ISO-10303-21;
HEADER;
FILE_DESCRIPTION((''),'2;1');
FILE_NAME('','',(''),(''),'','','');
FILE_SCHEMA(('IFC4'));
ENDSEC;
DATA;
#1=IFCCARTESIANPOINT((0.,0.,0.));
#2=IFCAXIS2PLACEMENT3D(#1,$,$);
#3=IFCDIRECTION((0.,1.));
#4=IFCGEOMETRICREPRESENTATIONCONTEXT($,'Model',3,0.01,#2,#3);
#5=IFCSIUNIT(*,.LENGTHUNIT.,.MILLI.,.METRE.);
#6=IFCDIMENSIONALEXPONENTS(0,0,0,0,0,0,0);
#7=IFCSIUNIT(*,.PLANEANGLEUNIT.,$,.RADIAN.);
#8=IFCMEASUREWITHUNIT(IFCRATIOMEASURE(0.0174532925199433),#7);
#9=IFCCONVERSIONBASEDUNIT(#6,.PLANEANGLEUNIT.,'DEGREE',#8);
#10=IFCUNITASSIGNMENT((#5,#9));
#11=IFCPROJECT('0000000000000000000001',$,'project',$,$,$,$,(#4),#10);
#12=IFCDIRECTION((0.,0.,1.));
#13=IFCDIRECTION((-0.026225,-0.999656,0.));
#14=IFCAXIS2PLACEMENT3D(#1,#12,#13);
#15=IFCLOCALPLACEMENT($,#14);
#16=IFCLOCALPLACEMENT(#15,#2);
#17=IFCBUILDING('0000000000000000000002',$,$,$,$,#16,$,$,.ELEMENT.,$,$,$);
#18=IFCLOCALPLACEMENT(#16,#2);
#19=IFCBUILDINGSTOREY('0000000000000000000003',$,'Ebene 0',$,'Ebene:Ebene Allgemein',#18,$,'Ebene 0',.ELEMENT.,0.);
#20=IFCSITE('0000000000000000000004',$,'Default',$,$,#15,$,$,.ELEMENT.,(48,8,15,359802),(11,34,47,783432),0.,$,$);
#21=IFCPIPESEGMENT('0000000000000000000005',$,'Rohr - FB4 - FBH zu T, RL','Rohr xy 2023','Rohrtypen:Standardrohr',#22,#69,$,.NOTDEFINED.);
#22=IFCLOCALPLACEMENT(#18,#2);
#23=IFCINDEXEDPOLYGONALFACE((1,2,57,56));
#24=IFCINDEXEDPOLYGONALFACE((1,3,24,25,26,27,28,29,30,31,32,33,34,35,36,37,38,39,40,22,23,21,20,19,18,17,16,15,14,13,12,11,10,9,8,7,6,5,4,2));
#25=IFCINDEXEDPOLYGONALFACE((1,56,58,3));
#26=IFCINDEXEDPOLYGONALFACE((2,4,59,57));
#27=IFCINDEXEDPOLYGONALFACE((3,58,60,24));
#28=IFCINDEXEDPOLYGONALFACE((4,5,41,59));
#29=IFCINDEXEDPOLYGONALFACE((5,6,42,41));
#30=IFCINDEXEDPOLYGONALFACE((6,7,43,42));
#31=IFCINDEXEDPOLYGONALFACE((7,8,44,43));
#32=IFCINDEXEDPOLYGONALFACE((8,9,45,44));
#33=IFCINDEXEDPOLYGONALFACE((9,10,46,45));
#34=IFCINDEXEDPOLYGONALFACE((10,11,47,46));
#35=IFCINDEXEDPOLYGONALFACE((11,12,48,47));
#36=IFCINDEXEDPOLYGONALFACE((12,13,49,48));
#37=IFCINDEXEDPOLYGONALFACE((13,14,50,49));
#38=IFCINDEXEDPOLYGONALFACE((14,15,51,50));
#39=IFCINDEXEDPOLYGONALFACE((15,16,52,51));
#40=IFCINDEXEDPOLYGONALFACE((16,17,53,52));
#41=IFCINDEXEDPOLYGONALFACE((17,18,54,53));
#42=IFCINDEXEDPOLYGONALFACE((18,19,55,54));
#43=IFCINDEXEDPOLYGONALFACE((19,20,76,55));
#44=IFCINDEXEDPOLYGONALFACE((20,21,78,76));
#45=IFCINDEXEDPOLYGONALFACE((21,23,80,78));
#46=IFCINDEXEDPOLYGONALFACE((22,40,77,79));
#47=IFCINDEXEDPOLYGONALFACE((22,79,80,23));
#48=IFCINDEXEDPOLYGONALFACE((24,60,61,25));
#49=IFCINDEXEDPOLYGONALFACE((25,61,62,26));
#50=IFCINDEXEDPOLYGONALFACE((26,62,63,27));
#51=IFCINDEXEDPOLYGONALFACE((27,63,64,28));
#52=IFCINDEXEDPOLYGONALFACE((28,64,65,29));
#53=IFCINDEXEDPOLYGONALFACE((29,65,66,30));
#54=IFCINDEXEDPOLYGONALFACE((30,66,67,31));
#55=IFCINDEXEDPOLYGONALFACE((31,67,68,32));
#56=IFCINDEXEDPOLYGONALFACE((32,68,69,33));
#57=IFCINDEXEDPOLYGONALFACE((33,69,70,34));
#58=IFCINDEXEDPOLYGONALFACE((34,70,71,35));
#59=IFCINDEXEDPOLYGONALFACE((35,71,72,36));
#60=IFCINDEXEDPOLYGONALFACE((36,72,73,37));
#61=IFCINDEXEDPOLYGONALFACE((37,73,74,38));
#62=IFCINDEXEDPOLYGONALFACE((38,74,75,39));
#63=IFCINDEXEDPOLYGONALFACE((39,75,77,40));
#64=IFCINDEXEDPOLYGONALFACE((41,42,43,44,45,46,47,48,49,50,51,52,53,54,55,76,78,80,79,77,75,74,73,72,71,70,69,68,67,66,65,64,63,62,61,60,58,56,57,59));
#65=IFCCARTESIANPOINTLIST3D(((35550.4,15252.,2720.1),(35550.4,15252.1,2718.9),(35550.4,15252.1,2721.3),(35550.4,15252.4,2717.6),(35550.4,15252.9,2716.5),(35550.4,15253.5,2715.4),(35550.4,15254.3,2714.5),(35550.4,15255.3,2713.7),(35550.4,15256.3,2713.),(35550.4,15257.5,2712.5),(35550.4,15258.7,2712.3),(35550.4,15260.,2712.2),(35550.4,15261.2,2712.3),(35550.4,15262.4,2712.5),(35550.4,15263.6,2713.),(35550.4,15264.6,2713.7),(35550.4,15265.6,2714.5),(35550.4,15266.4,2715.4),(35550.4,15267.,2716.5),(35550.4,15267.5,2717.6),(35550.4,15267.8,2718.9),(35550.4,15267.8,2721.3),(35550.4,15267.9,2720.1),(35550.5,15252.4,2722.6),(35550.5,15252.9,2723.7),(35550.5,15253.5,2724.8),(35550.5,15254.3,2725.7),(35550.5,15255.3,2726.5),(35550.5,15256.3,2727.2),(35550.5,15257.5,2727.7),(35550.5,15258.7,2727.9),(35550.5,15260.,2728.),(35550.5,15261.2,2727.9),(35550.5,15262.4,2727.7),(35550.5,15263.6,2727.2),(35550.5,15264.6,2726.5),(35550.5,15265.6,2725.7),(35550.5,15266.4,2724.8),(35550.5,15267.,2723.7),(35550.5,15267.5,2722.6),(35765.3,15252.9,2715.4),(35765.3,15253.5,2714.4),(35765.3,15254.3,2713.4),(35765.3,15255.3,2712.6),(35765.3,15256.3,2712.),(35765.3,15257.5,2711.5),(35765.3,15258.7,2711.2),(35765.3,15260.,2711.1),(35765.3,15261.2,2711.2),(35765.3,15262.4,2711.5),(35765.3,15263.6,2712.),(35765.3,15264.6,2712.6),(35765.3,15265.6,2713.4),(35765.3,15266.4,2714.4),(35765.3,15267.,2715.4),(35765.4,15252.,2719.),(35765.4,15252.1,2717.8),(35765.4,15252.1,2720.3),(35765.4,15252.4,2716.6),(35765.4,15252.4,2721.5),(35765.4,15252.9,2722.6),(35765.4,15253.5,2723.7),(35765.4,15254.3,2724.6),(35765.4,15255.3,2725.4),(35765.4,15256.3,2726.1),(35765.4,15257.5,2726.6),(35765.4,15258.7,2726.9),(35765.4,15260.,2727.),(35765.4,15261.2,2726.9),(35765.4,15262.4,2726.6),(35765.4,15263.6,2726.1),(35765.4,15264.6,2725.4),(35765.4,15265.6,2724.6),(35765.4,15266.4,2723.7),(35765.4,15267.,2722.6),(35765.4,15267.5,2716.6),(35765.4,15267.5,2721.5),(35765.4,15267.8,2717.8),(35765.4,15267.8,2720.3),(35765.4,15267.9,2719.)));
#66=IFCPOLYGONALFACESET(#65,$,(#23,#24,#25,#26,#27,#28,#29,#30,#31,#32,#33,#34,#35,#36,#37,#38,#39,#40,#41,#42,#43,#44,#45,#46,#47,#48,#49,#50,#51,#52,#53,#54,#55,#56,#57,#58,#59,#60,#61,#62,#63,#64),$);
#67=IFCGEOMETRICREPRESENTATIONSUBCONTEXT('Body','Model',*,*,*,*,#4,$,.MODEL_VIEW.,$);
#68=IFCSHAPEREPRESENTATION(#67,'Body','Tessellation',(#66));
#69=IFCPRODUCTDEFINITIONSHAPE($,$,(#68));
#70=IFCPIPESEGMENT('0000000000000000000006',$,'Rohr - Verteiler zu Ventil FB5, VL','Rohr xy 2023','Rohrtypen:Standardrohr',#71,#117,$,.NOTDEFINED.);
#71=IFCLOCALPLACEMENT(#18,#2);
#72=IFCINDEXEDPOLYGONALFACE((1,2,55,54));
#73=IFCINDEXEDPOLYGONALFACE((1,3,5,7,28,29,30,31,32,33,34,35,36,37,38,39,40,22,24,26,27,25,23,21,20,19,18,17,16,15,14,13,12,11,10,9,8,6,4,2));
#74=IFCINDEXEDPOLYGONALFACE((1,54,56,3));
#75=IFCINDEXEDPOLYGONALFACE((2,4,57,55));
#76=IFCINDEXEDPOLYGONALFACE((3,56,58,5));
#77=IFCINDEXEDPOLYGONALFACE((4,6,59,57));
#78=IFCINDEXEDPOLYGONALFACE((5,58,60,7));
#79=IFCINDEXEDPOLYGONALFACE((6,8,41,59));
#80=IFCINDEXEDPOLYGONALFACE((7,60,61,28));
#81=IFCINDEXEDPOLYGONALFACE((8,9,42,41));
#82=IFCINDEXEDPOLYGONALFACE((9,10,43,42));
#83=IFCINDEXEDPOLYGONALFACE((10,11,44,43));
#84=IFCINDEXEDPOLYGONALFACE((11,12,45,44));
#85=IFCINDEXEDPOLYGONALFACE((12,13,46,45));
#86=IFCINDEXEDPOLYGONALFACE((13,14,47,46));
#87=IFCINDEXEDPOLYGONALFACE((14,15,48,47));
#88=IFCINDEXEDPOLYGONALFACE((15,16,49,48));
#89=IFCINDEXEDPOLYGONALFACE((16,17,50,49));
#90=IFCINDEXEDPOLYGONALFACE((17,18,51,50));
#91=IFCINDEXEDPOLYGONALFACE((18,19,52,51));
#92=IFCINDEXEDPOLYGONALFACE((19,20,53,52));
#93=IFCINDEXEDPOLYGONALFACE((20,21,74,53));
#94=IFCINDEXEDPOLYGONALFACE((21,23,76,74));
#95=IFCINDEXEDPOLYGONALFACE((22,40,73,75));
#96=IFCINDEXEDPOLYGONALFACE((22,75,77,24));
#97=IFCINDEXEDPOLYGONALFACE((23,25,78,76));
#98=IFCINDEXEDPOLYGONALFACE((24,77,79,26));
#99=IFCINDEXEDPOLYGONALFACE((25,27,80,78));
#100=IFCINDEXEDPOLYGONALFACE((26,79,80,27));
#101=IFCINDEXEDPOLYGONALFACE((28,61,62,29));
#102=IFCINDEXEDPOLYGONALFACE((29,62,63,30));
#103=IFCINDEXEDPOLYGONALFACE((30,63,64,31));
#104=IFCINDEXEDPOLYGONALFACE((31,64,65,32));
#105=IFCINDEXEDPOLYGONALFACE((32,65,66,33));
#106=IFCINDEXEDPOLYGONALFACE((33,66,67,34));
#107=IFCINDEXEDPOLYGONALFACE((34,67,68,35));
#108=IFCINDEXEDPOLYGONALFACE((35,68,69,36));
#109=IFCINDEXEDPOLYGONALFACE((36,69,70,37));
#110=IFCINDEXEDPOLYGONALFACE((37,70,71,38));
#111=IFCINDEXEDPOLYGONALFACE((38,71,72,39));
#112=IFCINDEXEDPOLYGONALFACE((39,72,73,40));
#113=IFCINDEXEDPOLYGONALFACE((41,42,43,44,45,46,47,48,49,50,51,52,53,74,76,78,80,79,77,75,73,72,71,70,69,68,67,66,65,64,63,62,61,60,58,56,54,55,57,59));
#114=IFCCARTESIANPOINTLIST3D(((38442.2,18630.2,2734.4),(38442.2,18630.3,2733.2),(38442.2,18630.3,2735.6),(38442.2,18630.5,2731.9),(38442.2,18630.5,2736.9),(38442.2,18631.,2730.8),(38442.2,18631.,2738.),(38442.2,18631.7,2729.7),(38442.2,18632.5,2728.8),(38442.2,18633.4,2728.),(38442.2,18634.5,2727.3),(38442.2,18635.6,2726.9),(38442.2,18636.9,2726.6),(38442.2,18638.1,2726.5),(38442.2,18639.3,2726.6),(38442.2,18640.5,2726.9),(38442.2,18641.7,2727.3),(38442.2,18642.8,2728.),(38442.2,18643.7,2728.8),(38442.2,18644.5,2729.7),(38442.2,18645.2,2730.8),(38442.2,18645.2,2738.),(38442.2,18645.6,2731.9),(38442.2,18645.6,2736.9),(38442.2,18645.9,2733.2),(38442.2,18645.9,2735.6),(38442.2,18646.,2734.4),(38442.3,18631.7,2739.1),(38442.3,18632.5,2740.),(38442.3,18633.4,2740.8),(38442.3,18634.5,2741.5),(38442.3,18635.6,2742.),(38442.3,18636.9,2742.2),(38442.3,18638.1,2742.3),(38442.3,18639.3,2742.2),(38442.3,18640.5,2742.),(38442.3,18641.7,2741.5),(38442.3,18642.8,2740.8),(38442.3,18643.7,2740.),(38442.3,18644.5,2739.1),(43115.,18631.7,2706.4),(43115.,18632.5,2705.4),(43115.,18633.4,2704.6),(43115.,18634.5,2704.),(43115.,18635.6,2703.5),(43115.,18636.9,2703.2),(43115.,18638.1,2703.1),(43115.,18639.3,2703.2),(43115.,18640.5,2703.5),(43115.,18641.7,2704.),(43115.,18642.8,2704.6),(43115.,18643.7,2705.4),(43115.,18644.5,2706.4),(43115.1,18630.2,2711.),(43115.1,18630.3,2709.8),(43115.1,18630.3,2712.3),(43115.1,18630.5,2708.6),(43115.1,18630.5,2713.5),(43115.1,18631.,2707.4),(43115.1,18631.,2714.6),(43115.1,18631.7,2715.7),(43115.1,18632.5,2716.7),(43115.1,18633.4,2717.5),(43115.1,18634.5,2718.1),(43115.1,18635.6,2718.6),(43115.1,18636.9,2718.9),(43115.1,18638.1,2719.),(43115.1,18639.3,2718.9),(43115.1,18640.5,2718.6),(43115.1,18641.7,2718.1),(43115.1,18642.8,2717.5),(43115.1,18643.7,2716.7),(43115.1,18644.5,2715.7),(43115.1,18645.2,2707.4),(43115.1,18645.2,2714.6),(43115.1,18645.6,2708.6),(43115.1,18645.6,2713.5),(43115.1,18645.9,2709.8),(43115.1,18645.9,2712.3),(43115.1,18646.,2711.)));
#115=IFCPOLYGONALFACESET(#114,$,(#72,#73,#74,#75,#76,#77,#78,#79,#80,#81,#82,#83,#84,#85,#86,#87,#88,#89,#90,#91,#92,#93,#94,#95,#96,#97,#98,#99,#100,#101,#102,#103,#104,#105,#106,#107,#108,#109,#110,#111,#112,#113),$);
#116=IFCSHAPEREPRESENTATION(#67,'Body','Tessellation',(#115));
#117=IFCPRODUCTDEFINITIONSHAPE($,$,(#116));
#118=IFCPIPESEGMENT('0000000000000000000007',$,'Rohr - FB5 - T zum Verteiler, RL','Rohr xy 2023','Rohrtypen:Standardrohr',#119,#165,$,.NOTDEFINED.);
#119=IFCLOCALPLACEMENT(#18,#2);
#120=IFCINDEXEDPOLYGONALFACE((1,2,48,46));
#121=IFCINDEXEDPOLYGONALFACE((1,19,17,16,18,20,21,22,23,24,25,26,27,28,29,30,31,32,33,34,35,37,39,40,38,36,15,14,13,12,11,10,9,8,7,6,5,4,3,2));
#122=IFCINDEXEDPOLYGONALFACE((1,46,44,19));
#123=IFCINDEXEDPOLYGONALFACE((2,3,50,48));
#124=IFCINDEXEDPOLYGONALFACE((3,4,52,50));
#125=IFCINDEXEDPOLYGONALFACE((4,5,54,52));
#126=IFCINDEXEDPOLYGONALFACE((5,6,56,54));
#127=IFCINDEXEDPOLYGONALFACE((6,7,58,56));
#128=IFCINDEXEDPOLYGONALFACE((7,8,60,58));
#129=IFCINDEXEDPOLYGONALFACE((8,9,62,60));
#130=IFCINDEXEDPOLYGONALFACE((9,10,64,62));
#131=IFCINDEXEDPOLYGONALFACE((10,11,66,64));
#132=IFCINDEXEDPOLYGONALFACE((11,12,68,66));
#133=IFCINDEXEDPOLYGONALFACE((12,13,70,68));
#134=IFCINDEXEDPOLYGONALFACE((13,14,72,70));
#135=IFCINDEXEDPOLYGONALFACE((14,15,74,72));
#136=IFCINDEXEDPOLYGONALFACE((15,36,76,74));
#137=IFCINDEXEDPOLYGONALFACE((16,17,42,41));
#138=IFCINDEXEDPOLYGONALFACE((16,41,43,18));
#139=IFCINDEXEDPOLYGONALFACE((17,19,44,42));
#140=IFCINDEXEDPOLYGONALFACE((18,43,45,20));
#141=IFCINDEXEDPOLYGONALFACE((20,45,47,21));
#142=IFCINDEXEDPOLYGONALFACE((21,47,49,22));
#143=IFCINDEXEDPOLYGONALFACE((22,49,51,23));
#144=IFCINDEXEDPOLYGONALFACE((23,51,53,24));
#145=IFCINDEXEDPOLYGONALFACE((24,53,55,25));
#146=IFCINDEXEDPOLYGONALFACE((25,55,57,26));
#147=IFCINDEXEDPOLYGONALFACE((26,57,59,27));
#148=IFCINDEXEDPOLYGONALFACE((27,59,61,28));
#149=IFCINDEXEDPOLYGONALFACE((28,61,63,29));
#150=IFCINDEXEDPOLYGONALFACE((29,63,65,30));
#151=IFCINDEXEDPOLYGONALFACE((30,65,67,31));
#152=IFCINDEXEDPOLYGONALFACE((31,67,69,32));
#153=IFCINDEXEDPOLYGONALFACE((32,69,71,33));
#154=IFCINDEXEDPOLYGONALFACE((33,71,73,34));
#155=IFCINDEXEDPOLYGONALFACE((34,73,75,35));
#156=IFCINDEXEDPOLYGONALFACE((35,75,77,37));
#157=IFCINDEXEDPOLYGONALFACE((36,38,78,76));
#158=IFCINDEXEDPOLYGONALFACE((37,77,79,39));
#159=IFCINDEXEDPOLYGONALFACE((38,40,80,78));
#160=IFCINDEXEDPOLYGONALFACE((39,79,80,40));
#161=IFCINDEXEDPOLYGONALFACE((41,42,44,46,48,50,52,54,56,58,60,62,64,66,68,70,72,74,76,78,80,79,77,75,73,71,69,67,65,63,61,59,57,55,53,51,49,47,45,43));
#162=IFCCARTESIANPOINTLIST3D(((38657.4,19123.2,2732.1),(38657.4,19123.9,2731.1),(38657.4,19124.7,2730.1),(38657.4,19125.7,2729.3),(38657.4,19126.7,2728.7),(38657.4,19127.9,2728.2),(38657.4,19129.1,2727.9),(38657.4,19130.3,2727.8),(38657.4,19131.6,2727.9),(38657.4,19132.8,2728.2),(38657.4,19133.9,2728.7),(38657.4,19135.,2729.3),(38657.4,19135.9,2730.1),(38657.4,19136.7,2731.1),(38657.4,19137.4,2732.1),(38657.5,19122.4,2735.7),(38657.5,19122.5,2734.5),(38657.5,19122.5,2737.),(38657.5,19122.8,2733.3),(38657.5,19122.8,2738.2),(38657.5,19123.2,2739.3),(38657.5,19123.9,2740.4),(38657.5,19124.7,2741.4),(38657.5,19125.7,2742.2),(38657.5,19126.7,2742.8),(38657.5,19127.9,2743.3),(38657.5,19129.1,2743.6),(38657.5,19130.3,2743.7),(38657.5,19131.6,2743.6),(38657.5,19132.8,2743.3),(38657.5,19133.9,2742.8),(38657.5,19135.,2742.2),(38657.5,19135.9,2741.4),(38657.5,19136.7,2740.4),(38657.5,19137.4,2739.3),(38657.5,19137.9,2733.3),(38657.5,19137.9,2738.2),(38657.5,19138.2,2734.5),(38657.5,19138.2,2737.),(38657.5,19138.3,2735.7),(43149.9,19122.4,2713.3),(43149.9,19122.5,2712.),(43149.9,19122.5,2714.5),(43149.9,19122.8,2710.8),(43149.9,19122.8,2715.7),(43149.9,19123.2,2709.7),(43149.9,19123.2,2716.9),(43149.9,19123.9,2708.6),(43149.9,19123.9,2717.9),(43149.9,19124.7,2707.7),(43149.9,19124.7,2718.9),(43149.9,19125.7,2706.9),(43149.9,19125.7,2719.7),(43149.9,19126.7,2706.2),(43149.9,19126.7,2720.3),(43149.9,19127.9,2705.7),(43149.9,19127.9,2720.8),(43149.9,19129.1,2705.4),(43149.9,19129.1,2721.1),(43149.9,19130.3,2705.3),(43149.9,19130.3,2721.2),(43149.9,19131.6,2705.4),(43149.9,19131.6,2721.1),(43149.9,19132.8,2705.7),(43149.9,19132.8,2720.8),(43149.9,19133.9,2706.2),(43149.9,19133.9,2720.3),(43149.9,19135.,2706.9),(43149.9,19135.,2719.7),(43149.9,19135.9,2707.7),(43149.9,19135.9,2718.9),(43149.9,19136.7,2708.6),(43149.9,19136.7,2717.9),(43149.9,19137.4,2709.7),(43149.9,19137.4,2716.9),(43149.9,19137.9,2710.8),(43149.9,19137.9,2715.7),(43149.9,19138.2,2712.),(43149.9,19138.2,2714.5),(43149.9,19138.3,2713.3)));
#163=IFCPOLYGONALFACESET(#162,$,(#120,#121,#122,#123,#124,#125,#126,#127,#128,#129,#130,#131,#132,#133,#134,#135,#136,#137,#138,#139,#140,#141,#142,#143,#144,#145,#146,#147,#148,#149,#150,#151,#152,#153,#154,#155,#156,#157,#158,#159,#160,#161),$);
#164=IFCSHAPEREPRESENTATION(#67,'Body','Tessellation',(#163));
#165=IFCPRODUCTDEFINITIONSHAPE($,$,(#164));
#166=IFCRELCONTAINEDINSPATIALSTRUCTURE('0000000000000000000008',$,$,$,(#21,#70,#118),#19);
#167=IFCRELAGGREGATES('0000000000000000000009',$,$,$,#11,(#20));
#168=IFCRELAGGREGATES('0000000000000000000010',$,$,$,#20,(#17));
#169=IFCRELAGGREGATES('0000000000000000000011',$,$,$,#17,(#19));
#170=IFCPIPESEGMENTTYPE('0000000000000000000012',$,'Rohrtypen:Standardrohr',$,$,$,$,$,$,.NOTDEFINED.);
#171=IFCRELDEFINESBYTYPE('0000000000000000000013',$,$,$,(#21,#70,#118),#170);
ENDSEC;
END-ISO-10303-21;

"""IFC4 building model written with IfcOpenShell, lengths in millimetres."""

from ifc_helpers import new_model, entity, si_unit, converted_unit, direction, frame, origin, place, context, subcontext, project, spatial, indexed_curve, outline, extrude, type_object, element, save


model = new_model("IFC4")

# Units and contexts
model_context = context("Model", 3, precision=0.01, world=origin(), true_north=direction((0.0, 1.0)))
body_context = subcontext(model_context, "Body", "Model", "MODEL_VIEW")
ifc_project = project(units=[si_unit("LENGTHUNIT", "METRE", prefix="MILLI"), converted_unit("PLANEANGLEUNIT", "DEGREE", entity("IfcRatioMeasure", 0.0174532925199433), si_unit("PLANEANGLEUNIT", "RADIAN"), dimensions=[0, 0, 0, 0, 0, 0, 0])], contexts=[model_context])

# Site, building, storey
site_placement = place(None, frame((0.0, 0.0, 0.0), z_axis=(0.0, 0.0, 1.0), x_axis=(-0.026225, -0.999656, 0.0)))
site = spatial("IfcSite", under=ifc_project, at=site_placement, Name="Default", CompositionType="ELEMENT", RefLatitude=(48, 8, 15, 359802), RefLongitude=(11, 34, 47, 783432), RefElevation=0.0)
building_placement = place(site_placement, origin())
building = spatial("IfcBuilding", under=site, at=building_placement, CompositionType="ELEMENT")
storey_placement = place(building_placement, origin())
storey = spatial("IfcBuildingStorey", under=building, at=storey_placement, Name="Ebene 0", ObjectType="Ebene:Ebene Allgemein", LongName="Ebene 0", CompositionType="ELEMENT", Elevation=0.0)

# Pipe segments
pipe_segment_type = type_object("IfcPipeSegmentType", Name="Rohrtypen:Standardrohr", PredefinedType="NOTDEFINED")
pipe_segment_1_placement = place(storey_placement, origin())
element("IfcPipeSegment", 1, at=pipe_segment_1_placement, inside=storey, type_object=pipe_segment_type, Name="Rohr - FB4 - FBH zu T, RL", Description="Rohr xy 2023", ObjectType="Rohrtypen:Standardrohr", PredefinedType="NOTDEFINED", context=body_context, shape_type="SweptSolid", body=[
    extrude(outline(indexed_curve([(7.9, 0.0), (7.8, 1.2), (7.6, 2.5), (7.1, 3.6), (6.4, 4.7), (5.6, 5.6), (4.7, 6.4), (3.6, 7.1), (2.5, 7.6), (1.2, 7.8), (0.0, 7.9), (-1.2, 7.8), (-2.5, 7.6), (-3.6, 7.1), (-4.7, 6.4), (-5.6, 5.6), (-6.4, 4.7), (-7.1, 3.6), (-7.6, 2.5), (-7.8, 1.2), (-7.9, 0.0), (-7.8, -1.2), (-7.6, -2.5), (-7.1, -3.6), (-6.4, -4.7), (-5.6, -5.6), (-4.7, -6.4), (-3.6, -7.1), (-2.5, -7.6), (-1.2, -7.8), (0.0, -7.9), (1.2, -7.8), (2.5, -7.6), (3.6, -7.1), (4.7, -6.4), (5.6, -5.6), (6.4, -4.7), (7.1, -3.6), (7.6, -2.5), (7.8, -1.2), (7.9, 0.0)], self_intersect=False)), frame((35765.4, 15260.0, 2719.0), z_axis=(-0.999988, 0.0, 0.005), x_axis=(0.0, 1.0, 0.0)), (0.0, 0.0, 1.0), 214.9),
])
pipe_segment_2_placement = place(storey_placement, origin())
element("IfcPipeSegment", 2, at=pipe_segment_2_placement, inside=storey, type_object=pipe_segment_type, Name="Rohr - Verteiler zu Ventil FB5, VL", Description="Rohr xy 2023", ObjectType="Rohrtypen:Standardrohr", PredefinedType="NOTDEFINED", context=body_context, shape_type="SweptSolid", body=[
    extrude(outline(indexed_curve([(7.9, 0.0), (7.8, 1.2), (7.6, 2.5), (7.1, 3.6), (6.4, 4.7), (5.6, 5.6), (4.7, 6.4), (3.6, 7.1), (2.5, 7.6), (1.2, 7.8), (0.0, 7.9), (-1.2, 7.8), (-2.5, 7.6), (-3.6, 7.1), (-4.7, 6.4), (-5.6, 5.6), (-6.4, 4.7), (-7.1, 3.6), (-7.6, 2.5), (-7.8, 1.2), (-7.9, 0.0), (-7.8, -1.2), (-7.6, -2.5), (-7.1, -3.6), (-6.4, -4.7), (-5.6, -5.6), (-4.7, -6.4), (-3.6, -7.1), (-2.5, -7.6), (-1.2, -7.8), (0.0, -7.9), (1.2, -7.8), (2.5, -7.6), (3.6, -7.1), (4.7, -6.4), (5.6, -5.6), (6.4, -4.7), (7.1, -3.6), (7.6, -2.5), (7.8, -1.2), (7.9, 0.0)], self_intersect=False)), frame((43115.1, 18638.1, 2711.0), z_axis=(-0.999988, 0.0, 0.005), x_axis=(0.0, 1.0, 0.0)), (0.0, 0.0, 1.0), 4672.9),
])
pipe_segment_3_placement = place(storey_placement, origin())
element("IfcPipeSegment", 3, at=pipe_segment_3_placement, inside=storey, type_object=pipe_segment_type, Name="Rohr - FB5 - T zum Verteiler, RL", Description="Rohr xy 2023", ObjectType="Rohrtypen:Standardrohr", PredefinedType="NOTDEFINED", context=body_context, shape_type="SweptSolid", body=[
    extrude(outline(indexed_curve([(7.9, 0.0), (7.8, 1.2), (7.6, 2.5), (7.1, 3.6), (6.4, 4.7), (5.6, 5.6), (4.7, 6.4), (3.6, 7.1), (2.5, 7.6), (1.2, 7.8), (0.0, 7.9), (-1.2, 7.8), (-2.5, 7.6), (-3.6, 7.1), (-4.7, 6.4), (-5.6, 5.6), (-6.4, 4.7), (-7.1, 3.6), (-7.6, 2.5), (-7.8, 1.2), (-7.9, 0.0), (-7.8, -1.2), (-7.6, -2.5), (-7.1, -3.6), (-6.4, -4.7), (-5.6, -5.6), (-4.7, -6.4), (-3.6, -7.1), (-2.5, -7.6), (-1.2, -7.8), (0.0, -7.9), (1.2, -7.8), (2.5, -7.6), (3.6, -7.1), (4.7, -6.4), (5.6, -5.6), (6.4, -4.7), (7.1, -3.6), (7.6, -2.5), (7.8, -1.2), (7.9, 0.0)], self_intersect=False)), frame((43149.9, 19130.3, 2713.3), z_axis=(-0.999988, 0.0, 0.005), x_axis=(0.0, 1.0, 0.0)), (0.0, 0.0, 1.0), 4492.5),
])

save(model, "model.ifc")
